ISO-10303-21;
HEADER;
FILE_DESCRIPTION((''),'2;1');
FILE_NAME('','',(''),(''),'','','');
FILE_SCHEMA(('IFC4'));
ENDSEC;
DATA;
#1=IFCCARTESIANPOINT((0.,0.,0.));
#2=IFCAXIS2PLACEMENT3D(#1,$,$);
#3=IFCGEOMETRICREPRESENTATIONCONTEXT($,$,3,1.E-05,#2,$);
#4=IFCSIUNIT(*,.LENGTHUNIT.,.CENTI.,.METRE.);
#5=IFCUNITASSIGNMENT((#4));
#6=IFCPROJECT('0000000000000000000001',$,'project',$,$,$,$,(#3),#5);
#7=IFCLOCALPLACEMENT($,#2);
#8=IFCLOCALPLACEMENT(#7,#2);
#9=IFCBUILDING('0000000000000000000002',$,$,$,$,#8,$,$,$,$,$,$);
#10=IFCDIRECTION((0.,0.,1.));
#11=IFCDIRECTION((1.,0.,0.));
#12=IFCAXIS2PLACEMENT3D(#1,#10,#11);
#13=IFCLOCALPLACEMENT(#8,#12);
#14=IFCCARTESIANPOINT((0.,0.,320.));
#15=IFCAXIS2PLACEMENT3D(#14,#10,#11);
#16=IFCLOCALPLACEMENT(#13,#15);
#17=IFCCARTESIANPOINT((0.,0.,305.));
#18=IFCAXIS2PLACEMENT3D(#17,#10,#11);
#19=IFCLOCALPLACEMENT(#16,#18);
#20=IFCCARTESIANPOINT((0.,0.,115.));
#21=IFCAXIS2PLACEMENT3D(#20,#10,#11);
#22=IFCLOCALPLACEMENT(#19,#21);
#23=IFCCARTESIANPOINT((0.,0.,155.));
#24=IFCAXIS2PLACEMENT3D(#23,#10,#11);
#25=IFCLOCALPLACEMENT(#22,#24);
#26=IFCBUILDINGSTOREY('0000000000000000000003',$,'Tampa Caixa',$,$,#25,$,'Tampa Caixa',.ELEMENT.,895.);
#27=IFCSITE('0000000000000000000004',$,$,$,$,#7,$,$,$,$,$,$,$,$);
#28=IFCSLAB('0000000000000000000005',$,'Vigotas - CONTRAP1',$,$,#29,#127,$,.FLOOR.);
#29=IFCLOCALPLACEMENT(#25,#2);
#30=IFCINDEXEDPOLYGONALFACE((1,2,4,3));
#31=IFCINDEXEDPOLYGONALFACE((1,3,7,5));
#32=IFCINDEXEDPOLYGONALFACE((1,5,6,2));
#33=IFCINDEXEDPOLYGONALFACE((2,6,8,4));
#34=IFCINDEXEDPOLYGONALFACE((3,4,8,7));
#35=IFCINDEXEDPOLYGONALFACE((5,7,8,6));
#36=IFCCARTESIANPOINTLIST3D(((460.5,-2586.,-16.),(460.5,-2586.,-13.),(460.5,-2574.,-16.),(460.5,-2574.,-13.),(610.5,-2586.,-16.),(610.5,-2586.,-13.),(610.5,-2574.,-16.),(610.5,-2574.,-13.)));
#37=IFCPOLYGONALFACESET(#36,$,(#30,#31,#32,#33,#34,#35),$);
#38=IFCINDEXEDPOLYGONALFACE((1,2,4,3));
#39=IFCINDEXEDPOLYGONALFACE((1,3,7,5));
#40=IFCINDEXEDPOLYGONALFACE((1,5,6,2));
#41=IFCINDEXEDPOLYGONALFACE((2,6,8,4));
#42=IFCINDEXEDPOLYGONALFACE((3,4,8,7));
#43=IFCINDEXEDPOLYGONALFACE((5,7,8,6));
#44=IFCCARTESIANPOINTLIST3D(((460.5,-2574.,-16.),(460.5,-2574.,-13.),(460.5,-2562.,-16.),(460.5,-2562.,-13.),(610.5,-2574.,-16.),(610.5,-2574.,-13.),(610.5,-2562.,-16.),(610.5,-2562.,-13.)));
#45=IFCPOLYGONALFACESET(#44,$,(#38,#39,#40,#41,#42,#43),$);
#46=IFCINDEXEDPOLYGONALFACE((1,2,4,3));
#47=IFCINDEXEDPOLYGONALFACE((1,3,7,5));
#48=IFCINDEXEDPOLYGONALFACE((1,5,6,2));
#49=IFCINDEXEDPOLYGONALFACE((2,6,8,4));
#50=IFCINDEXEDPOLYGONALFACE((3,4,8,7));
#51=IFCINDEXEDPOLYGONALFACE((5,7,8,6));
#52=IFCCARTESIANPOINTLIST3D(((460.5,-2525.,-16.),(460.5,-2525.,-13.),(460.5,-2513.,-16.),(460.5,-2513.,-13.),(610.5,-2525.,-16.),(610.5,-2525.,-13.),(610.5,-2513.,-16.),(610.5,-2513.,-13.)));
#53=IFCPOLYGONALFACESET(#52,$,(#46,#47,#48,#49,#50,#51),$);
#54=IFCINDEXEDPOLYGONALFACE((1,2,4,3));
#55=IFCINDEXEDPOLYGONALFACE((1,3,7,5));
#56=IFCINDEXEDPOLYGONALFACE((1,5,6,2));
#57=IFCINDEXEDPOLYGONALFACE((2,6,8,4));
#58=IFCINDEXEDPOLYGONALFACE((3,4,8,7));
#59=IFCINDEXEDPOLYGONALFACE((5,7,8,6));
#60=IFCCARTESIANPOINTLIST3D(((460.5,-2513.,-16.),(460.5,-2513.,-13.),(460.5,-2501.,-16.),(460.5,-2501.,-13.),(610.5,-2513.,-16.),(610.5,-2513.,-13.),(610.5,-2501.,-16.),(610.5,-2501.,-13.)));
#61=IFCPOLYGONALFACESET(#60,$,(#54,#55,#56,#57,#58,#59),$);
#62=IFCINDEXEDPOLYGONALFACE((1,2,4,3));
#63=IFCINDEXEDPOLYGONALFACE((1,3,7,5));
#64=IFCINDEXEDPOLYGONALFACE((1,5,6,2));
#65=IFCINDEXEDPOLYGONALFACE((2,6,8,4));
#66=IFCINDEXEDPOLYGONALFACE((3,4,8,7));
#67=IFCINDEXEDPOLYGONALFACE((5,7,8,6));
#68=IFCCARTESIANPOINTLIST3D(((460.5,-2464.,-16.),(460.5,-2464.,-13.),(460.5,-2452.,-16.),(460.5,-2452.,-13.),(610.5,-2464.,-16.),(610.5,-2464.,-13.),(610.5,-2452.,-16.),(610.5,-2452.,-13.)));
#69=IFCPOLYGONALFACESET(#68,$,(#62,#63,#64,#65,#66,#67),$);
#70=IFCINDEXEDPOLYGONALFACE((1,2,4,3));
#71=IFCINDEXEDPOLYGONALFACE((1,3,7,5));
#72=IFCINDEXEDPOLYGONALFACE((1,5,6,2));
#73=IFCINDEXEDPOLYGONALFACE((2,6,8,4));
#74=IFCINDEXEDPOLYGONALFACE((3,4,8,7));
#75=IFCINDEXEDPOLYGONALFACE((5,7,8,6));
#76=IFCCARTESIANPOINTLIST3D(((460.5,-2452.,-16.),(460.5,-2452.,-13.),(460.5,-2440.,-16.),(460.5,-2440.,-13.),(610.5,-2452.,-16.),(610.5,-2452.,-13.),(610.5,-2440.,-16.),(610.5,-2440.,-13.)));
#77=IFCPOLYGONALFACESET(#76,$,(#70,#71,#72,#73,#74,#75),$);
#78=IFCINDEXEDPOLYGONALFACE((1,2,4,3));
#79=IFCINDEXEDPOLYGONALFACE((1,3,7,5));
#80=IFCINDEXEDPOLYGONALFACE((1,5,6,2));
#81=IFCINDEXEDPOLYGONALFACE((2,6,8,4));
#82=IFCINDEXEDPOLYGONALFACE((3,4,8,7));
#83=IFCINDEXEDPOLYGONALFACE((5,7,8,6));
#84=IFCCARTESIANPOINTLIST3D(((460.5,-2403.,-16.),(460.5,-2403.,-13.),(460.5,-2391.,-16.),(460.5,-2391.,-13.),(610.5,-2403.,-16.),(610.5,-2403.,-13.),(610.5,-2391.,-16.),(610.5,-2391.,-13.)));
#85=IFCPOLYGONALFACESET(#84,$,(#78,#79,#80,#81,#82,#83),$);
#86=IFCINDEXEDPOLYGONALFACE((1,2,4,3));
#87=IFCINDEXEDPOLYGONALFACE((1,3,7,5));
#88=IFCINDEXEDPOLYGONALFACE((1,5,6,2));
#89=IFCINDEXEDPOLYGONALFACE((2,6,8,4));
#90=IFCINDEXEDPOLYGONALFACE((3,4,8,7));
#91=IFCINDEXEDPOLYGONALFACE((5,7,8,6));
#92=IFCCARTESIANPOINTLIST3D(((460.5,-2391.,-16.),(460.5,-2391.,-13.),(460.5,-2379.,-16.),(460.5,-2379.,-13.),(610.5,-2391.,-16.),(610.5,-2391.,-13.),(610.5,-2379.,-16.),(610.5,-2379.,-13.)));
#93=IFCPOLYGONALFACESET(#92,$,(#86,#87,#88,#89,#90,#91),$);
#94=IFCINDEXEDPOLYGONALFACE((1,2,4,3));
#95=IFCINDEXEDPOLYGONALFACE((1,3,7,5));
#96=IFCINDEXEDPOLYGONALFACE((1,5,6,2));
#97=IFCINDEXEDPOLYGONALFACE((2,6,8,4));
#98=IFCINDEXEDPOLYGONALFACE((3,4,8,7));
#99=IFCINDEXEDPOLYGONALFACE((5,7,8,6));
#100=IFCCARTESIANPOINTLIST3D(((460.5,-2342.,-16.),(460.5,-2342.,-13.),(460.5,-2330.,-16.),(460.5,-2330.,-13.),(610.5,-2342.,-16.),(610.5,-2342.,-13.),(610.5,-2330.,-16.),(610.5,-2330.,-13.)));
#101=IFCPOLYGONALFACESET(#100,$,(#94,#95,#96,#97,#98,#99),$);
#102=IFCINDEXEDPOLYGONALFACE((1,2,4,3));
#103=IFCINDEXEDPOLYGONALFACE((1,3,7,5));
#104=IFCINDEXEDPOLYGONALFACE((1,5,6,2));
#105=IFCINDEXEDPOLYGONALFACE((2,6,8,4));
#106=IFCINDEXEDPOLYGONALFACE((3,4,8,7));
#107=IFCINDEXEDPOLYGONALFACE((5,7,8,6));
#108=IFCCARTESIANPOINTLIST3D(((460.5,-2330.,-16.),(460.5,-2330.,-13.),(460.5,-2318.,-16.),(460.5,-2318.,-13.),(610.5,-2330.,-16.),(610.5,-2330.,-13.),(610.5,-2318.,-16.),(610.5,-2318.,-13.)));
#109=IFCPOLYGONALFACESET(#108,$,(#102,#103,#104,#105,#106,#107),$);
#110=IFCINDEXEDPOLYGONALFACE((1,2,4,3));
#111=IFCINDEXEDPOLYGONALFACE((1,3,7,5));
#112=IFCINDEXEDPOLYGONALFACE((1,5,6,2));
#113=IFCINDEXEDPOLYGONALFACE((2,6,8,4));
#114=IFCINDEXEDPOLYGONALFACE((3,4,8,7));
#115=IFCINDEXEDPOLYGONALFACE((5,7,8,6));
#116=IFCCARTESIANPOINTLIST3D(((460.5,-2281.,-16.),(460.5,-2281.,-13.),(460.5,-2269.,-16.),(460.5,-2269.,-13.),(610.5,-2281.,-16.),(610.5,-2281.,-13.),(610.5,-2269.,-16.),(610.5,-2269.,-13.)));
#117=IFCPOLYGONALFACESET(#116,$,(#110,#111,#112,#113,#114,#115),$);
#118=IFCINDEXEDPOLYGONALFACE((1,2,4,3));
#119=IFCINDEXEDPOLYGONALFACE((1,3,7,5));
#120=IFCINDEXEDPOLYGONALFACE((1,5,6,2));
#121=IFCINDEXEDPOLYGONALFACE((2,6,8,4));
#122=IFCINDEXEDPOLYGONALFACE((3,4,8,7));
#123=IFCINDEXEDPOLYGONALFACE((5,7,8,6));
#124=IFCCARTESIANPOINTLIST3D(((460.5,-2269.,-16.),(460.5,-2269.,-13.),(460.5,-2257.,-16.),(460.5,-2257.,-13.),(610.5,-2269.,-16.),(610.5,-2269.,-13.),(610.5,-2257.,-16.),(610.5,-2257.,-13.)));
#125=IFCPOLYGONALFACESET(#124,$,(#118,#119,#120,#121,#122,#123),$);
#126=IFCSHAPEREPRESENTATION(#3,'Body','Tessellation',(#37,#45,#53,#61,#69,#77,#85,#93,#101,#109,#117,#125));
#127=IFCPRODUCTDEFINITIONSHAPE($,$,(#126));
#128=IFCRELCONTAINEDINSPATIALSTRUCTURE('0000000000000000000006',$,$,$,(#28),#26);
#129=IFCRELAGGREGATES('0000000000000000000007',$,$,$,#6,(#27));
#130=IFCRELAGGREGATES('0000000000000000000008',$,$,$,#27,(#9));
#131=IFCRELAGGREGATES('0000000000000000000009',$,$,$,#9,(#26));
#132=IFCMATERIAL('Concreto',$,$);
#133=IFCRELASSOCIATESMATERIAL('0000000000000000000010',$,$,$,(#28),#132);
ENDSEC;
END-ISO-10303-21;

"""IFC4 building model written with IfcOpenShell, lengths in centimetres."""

from ifc_helpers import new_model, si_unit, frame, origin, origin_with_axes, place, context, project, spatial, polyline, outline, extrude, material, element, save


model = new_model("IFC4")

# Units and contexts
context_of_model = context(None, 3, precision=1e-05, world=origin())
ifc_project = project(units=[si_unit("LENGTHUNIT", "METRE", prefix="CENTI")], contexts=[context_of_model])

# Site, building, storey
site_placement = place(None, origin())
site = spatial("IfcSite", under=ifc_project, at=site_placement)
building_placement = place(site_placement, origin())
building = spatial("IfcBuilding", under=site, at=building_placement)
placement_1 = place(building_placement, origin_with_axes())
placement_2 = place(placement_1, frame((0.0, 0.0, 320.0), z_axis=(0.0, 0.0, 1.0), x_axis=(1.0, 0.0, 0.0)))
placement_3 = place(placement_2, frame((0.0, 0.0, 305.0), z_axis=(0.0, 0.0, 1.0), x_axis=(1.0, 0.0, 0.0)))
placement_4 = place(placement_3, frame((0.0, 0.0, 115.0), z_axis=(0.0, 0.0, 1.0), x_axis=(1.0, 0.0, 0.0)))
storey_placement = place(placement_4, frame((0.0, 0.0, 155.0), z_axis=(0.0, 0.0, 1.0), x_axis=(1.0, 0.0, 0.0)))
storey = spatial("IfcBuildingStorey", under=building, at=storey_placement, Name="Tampa Caixa", LongName="Tampa Caixa", CompositionType="ELEMENT", Elevation=895.0)

# Shared definitions
ifc_material = material(Name="Concreto")

# Slab
slab_placement = place(storey_placement, frame((535.5, -2421.5, -13.0), z_axis=(0.0, 0.0, 1.0), x_axis=(1.0, 0.0, 0.0)))
element("IfcSlab", 1, at=slab_placement, inside=storey, material=ifc_material, Name="Vigotas - CONTRAP1", PredefinedType="FLOOR", context=context_of_model, shape_type="SolidModel", body=[
    extrude(outline(polyline([(6.0, 1.5), (-6.0, 1.5), (-6.0, -1.5), (6.0, -1.5), (6.0, 1.5), (6.0, 1.5)])), frame((-75.0, -158.5, -1.5), z_axis=(1.0, 0.0, 0.0), x_axis=(0.0, -1.0, 0.0)), (0.0, 0.0, 1.0), 150.0),
    extrude(outline(polyline([(6.0, 1.5), (-6.0, 1.5), (-6.0, -1.5), (6.0, -1.5), (6.0, 1.5), (6.0, 1.5)])), frame((-75.0, -146.5, -1.5), z_axis=(1.0, 0.0, 0.0), x_axis=(0.0, -1.0, 0.0)), (0.0, 0.0, 1.0), 150.0),
    extrude(outline(polyline([(6.0, 1.5), (-6.0, 1.5), (-6.0, -1.5), (6.0, -1.5), (6.0, 1.5), (6.0, 1.5)])), frame((-75.0, -97.5, -1.5), z_axis=(1.0, 0.0, 0.0), x_axis=(0.0, -1.0, 0.0)), (0.0, 0.0, 1.0), 150.0),
    extrude(outline(polyline([(6.0, 1.5), (-6.0, 1.5), (-6.0, -1.5), (6.0, -1.5), (6.0, 1.5), (6.0, 1.5)])), frame((-75.0, -85.5, -1.5), z_axis=(1.0, 0.0, 0.0), x_axis=(0.0, -1.0, 0.0)), (0.0, 0.0, 1.0), 150.0),
    extrude(outline(polyline([(6.0, 1.5), (-6.0, 1.5), (-6.0, -1.5), (6.0, -1.5), (6.0, 1.5), (6.0, 1.5)])), frame((-75.0, -36.5, -1.5), z_axis=(1.0, 0.0, 0.0), x_axis=(0.0, -1.0, 0.0)), (0.0, 0.0, 1.0), 150.0),
    extrude(outline(polyline([(6.0, 1.5), (-6.0, 1.5), (-6.0, -1.5), (6.0, -1.5), (6.0, 1.5), (6.0, 1.5)])), frame((-75.0, -24.5, -1.5), z_axis=(1.0, 0.0, 0.0), x_axis=(0.0, -1.0, 0.0)), (0.0, 0.0, 1.0), 150.0),
    extrude(outline(polyline([(6.0, 1.5), (-6.0, 1.5), (-6.0, -1.5), (6.0, -1.5), (6.0, 1.5), (6.0, 1.5)])), frame((-75.0, 24.5, -1.5), z_axis=(1.0, 0.0, 0.0), x_axis=(0.0, -1.0, 0.0)), (0.0, 0.0, 1.0), 150.0),
    extrude(outline(polyline([(6.0, 1.5), (-6.0, 1.5), (-6.0, -1.5), (6.0, -1.5), (6.0, 1.5), (6.0, 1.5)])), frame((-75.0, 36.5, -1.5), z_axis=(1.0, 0.0, 0.0), x_axis=(0.0, -1.0, 0.0)), (0.0, 0.0, 1.0), 150.0),
    extrude(outline(polyline([(6.0, 1.5), (-6.0, 1.5), (-6.0, -1.5), (6.0, -1.5), (6.0, 1.5), (6.0, 1.5)])), frame((-75.0, 85.5, -1.5), z_axis=(1.0, 0.0, 0.0), x_axis=(0.0, -1.0, 0.0)), (0.0, 0.0, 1.0), 150.0),
    extrude(outline(polyline([(6.0, 1.5), (-6.0, 1.5), (-6.0, -1.5), (6.0, -1.5), (6.0, 1.5), (6.0, 1.5)])), frame((-75.0, 97.5, -1.5), z_axis=(1.0, 0.0, 0.0), x_axis=(0.0, -1.0, 0.0)), (0.0, 0.0, 1.0), 150.0),
    extrude(outline(polyline([(6.0, 1.5), (-6.0, 1.5), (-6.0, -1.5), (6.0, -1.5), (6.0, 1.5), (6.0, 1.5)])), frame((-75.0, 146.5, -1.5), z_axis=(1.0, 0.0, 0.0), x_axis=(0.0, -1.0, 0.0)), (0.0, 0.0, 1.0), 150.0),
    extrude(outline(polyline([(6.0, 1.5), (-6.0, 1.5), (-6.0, -1.5), (6.0, -1.5), (6.0, 1.5), (6.0, 1.5)])), frame((-75.0, 158.5, -1.5), z_axis=(1.0, 0.0, 0.0), x_axis=(0.0, -1.0, 0.0)), (0.0, 0.0, 1.0), 150.0),
])

save(model, "model.ifc")
